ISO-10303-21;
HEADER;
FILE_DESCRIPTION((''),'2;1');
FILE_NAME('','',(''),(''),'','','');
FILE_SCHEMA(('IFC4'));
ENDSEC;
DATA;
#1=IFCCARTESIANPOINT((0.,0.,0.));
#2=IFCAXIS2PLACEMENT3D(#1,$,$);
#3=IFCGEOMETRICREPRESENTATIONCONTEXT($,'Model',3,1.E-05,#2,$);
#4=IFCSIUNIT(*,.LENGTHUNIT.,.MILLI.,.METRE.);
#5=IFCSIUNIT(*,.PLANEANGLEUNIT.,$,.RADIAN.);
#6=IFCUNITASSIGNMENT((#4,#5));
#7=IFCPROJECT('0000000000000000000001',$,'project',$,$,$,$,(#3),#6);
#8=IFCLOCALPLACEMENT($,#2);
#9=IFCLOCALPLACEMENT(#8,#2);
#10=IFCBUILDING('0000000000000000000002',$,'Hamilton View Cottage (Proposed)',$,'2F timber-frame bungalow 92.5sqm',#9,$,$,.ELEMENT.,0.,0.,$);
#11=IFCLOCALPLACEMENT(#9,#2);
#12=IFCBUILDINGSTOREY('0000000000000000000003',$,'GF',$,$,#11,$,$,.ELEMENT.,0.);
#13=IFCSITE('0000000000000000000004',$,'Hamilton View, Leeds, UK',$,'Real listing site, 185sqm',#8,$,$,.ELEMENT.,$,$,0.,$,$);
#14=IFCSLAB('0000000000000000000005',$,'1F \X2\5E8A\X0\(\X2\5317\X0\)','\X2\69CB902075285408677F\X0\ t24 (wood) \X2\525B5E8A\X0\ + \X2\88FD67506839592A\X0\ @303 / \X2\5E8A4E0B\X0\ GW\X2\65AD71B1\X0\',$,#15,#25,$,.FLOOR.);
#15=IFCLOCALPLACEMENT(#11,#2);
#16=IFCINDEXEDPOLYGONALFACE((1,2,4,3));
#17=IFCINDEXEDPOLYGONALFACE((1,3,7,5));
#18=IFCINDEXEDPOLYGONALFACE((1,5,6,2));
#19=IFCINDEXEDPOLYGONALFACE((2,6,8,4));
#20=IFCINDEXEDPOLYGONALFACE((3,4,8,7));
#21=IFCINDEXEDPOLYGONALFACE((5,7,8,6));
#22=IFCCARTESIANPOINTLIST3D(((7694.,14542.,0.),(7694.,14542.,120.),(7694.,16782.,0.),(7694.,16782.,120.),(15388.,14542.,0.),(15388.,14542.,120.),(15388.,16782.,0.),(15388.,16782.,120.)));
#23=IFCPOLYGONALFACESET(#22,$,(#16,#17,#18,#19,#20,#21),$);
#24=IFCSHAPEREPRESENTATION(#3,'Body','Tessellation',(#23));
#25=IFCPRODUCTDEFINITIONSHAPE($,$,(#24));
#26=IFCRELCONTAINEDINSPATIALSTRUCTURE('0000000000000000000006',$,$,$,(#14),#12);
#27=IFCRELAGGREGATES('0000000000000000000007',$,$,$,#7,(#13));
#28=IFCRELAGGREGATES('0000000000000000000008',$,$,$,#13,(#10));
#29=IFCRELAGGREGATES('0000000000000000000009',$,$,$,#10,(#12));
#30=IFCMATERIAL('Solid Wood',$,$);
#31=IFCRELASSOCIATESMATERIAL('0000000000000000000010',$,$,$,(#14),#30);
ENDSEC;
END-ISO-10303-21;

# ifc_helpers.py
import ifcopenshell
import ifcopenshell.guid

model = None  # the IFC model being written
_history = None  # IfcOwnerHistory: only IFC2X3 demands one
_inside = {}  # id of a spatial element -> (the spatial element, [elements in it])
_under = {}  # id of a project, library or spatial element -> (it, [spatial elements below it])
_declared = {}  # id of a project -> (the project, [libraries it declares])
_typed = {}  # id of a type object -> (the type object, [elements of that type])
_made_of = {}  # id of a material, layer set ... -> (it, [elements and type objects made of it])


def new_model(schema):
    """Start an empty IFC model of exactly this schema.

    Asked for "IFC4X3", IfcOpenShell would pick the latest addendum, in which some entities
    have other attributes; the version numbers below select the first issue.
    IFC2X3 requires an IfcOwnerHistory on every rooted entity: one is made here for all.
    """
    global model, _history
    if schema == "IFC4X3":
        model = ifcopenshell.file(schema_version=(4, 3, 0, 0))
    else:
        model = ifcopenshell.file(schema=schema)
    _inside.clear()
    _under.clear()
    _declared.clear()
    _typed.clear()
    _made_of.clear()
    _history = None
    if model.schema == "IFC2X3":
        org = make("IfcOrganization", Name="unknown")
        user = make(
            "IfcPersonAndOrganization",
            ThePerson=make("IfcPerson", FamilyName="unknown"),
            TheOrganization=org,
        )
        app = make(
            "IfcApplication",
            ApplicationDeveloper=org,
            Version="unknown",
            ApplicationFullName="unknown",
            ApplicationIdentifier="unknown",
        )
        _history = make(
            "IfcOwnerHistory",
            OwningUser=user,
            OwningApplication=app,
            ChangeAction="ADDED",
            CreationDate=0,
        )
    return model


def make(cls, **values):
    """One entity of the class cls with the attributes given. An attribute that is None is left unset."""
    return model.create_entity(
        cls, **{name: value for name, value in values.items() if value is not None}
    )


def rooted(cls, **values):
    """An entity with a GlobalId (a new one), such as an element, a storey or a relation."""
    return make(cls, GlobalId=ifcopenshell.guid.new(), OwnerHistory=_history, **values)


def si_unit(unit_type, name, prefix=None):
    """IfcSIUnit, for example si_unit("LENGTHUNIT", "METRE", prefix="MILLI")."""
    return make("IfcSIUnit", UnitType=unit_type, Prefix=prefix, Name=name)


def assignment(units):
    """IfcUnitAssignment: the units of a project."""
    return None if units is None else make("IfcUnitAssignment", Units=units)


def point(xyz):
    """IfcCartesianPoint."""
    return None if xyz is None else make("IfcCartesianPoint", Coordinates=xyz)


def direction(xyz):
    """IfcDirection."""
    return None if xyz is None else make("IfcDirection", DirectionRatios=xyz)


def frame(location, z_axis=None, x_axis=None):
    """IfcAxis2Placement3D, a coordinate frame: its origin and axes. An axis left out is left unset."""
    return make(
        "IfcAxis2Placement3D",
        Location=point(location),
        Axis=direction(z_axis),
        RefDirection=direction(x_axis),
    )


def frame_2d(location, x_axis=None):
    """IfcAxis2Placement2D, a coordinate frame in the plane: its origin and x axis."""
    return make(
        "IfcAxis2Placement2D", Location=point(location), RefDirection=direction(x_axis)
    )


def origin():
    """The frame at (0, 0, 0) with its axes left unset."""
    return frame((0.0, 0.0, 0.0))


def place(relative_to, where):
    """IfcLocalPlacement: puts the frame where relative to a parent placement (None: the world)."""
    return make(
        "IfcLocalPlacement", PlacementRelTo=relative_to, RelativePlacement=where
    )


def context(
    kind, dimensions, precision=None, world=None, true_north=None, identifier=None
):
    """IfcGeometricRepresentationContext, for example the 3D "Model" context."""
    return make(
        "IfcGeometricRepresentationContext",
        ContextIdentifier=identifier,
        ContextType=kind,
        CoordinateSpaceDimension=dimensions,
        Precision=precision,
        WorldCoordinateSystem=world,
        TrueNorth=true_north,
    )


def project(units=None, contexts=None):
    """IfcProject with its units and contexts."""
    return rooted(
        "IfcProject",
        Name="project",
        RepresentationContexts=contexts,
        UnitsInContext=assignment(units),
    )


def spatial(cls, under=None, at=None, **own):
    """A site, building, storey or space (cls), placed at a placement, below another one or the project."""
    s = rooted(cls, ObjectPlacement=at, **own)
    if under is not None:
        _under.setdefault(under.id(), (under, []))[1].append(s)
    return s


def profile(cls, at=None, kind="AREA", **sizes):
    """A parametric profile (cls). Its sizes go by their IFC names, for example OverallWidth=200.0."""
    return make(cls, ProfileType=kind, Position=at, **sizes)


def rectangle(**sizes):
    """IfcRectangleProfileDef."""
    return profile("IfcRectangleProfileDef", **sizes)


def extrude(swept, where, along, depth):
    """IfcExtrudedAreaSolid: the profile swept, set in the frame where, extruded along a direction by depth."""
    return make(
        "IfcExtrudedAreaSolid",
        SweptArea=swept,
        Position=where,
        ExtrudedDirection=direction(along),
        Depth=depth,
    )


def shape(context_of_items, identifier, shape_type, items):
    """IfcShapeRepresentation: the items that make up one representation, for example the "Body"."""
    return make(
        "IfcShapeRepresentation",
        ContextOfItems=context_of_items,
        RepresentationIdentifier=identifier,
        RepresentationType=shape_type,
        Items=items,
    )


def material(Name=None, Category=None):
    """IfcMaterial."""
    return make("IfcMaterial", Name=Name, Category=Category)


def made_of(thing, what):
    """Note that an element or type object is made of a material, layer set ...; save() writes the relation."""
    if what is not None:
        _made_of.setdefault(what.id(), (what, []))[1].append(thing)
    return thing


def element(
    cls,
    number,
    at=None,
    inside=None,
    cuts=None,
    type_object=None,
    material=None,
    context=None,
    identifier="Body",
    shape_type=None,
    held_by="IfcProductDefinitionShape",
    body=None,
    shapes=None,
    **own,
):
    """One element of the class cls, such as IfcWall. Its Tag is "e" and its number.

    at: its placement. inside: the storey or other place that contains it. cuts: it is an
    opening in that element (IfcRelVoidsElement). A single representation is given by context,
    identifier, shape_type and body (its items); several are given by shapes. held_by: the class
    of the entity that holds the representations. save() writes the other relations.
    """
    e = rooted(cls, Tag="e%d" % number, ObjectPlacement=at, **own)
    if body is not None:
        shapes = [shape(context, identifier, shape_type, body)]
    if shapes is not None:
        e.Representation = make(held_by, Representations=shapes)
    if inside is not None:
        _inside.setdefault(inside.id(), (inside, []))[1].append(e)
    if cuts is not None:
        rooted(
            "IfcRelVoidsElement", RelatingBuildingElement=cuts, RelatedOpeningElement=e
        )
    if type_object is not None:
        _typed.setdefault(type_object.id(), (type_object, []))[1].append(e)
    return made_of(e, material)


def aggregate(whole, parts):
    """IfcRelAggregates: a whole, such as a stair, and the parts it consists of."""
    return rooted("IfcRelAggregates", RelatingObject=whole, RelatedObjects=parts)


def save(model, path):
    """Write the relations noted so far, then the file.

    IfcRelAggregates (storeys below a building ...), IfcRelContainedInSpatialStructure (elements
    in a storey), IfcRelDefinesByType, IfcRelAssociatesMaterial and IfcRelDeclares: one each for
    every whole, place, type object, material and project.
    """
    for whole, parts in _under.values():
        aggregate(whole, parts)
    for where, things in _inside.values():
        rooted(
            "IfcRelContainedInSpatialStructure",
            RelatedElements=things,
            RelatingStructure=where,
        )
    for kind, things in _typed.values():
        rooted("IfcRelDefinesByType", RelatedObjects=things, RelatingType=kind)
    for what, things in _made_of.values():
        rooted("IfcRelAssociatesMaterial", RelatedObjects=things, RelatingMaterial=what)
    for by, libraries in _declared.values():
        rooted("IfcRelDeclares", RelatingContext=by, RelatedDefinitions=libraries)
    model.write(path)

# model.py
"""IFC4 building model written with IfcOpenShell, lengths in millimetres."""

from ifc_helpers import new_model, si_unit, frame, frame_2d, origin, place, context, project, spatial, rectangle, extrude, material, element, save


model = new_model("IFC4")

# Units and contexts
model_context = context("Model", 3, precision=1e-05, world=origin())
ifc_project = project(units=[si_unit("LENGTHUNIT", "METRE", prefix="MILLI"), si_unit("PLANEANGLEUNIT", "RADIAN")], contexts=[model_context])

# Site, building, storey
site_placement = place(None, origin())
site = spatial("IfcSite", under=ifc_project, at=site_placement, Name="Hamilton View, Leeds, UK", ObjectType="Real listing site, 185sqm", CompositionType="ELEMENT", RefElevation=0.0)
building_placement = place(site_placement, origin())
building = spatial("IfcBuilding", under=site, at=building_placement, Name="Hamilton View Cottage (Proposed)", ObjectType="2F timber-frame bungalow 92.5sqm", CompositionType="ELEMENT", ElevationOfRefHeight=0.0, ElevationOfTerrain=0.0)
storey_placement = place(building_placement, origin())
storey = spatial("IfcBuildingStorey", under=building, at=storey_placement, Name="GF", CompositionType="ELEMENT", Elevation=0.0)

# Slab
ifc_material_1 = material(Name="Solid Wood")
slab_1_placement = place(storey_placement, frame((3847.0, 7271.0, 0.0)))
element("IfcSlab", 1, at=slab_1_placement, inside=storey, material=ifc_material_1, Name="1F 床(北)", Description="構造用合板 t24 (wood) 剛床 + 製材根太 @303 / 床下 GW断熱", PredefinedType="FLOOR", context=model_context, shape_type="SweptSolid", body=[
    extrude(rectangle(XDim=7694.0, YDim=2240.0, at=frame_2d((3847.0, 1120.0))), frame((3847.0, 7271.0, 0.0)), (0.0, 0.0, 1.0), 120.0),
])

save(model, "model.ifc")
